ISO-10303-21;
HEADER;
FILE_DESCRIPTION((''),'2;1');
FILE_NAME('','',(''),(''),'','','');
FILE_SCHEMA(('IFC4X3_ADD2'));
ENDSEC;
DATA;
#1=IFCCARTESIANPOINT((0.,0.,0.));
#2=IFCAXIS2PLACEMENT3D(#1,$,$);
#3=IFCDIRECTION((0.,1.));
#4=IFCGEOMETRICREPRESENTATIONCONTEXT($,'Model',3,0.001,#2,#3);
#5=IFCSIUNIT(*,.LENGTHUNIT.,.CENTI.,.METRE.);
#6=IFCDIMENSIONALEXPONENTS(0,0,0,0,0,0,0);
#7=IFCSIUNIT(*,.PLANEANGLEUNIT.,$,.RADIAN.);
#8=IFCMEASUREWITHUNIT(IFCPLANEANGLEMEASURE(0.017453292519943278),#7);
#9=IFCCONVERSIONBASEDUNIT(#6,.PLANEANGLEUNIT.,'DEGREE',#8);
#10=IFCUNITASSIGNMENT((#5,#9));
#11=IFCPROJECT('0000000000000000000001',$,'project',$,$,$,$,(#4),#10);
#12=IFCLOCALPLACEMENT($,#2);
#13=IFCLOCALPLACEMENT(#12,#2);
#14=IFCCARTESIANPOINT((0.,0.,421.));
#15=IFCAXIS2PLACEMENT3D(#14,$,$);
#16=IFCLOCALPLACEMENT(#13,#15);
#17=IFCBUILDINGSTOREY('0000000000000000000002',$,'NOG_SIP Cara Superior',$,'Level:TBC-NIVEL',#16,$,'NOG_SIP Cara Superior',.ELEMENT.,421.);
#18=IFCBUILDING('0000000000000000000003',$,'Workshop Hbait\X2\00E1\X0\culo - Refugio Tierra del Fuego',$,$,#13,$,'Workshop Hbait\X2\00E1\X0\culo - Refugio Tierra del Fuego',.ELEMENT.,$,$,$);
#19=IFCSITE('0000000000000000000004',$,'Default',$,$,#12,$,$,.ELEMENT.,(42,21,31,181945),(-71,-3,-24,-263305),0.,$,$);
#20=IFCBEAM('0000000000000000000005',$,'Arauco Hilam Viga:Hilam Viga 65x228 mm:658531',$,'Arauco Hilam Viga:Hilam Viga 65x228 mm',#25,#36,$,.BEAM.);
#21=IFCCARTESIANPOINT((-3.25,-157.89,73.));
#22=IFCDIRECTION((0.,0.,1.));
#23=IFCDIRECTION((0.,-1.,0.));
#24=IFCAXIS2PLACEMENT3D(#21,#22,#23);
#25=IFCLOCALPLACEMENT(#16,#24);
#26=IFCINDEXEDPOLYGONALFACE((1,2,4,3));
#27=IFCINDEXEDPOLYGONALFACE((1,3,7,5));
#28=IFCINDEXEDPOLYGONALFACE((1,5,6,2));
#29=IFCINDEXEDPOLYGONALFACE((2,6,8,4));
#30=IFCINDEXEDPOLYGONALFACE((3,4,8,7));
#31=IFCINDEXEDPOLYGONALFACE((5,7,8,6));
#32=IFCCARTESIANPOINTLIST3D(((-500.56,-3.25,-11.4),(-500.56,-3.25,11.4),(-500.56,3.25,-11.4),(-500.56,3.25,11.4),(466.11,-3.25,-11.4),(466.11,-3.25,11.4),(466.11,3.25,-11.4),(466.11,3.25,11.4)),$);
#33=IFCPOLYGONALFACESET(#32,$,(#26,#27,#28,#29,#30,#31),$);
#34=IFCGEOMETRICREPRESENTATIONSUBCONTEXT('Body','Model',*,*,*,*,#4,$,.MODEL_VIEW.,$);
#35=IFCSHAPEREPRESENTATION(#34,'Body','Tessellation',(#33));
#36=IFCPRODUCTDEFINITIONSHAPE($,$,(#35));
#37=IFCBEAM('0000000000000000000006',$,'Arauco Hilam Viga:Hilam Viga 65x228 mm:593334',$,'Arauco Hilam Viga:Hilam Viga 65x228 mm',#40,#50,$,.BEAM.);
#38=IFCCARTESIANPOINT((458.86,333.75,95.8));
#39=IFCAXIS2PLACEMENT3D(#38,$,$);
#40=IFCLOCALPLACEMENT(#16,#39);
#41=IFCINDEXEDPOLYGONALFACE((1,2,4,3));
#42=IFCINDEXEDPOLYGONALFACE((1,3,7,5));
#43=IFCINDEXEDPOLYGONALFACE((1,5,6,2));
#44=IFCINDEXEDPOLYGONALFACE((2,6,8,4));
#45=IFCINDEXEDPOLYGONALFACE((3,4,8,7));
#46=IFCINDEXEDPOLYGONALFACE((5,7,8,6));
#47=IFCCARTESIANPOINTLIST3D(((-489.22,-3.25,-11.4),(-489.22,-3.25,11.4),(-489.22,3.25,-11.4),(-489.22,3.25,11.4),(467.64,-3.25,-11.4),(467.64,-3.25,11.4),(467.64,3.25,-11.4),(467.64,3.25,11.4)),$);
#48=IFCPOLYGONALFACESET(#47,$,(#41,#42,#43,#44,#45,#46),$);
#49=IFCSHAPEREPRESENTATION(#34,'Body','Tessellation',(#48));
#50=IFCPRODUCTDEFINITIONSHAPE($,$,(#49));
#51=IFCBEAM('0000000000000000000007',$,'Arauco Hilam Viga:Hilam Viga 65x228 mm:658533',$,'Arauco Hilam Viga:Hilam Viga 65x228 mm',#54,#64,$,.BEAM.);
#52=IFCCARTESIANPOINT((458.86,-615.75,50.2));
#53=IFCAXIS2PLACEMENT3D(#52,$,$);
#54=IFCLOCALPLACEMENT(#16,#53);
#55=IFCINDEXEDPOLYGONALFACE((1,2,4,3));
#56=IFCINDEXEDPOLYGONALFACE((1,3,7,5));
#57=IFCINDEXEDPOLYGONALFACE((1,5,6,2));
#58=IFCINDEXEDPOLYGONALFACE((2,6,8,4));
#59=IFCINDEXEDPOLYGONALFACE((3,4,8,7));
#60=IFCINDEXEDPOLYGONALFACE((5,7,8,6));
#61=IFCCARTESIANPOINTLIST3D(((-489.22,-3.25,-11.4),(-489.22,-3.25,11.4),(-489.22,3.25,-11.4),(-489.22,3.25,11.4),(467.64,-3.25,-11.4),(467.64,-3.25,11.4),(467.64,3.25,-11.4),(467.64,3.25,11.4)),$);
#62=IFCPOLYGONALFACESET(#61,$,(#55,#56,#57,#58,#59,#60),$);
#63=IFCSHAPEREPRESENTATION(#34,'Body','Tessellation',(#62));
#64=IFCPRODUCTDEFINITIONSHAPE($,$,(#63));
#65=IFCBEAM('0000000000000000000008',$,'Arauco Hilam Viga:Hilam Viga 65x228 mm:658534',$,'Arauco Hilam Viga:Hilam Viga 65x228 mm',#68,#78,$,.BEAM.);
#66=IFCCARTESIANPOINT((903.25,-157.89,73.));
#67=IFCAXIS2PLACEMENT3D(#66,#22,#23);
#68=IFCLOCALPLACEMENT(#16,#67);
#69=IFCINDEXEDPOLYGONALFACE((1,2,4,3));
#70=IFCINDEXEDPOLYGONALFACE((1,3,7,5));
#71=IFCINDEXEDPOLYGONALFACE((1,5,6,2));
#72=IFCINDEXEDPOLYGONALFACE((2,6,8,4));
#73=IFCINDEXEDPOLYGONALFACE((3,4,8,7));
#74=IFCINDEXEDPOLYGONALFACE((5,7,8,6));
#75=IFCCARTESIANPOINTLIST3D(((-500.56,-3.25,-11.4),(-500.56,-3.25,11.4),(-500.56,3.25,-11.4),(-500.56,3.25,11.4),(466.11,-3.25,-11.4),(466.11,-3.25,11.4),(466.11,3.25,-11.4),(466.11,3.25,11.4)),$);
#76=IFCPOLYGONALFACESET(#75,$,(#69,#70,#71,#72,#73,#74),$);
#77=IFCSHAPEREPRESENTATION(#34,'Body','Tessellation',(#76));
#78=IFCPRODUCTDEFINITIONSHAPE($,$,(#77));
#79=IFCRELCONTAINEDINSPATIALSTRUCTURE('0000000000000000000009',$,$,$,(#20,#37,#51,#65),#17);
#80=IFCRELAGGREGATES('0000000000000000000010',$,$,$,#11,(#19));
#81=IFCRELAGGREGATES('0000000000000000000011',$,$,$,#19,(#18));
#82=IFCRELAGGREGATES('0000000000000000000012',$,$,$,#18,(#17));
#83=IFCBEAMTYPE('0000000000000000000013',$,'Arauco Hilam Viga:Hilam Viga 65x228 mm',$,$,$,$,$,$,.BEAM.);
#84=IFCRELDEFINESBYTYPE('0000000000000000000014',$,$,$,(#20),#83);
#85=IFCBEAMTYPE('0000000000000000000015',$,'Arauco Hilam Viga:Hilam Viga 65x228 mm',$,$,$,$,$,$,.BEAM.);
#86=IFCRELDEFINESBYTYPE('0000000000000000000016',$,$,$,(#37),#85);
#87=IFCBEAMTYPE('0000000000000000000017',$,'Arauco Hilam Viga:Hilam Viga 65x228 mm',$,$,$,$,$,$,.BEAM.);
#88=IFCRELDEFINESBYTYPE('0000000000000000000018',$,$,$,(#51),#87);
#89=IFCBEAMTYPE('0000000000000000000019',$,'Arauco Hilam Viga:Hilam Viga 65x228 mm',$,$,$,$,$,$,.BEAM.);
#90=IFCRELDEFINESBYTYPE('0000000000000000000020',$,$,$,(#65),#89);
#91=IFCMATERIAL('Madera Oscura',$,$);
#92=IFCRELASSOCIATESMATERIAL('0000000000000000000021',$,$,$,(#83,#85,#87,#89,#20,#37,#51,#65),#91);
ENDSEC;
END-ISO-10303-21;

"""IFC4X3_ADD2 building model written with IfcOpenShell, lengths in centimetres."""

from ifc_helpers import new_model, entity, si_unit, converted_unit, direction, frame, origin, origin_2d_with_axis, place, context, subcontext, project, spatial, rectangle, extrude, source, transform, mapped, material, material_profile, profile_set, profile_usage, type_object, type_shapes, element, save


model = new_model("IFC4X3_ADD2")

# Units and contexts
model_context = context("Model", 3, precision=0.001, world=origin(), true_north=direction((0.0, 1.0)))
body_context = subcontext(model_context, "Body", "Model", "MODEL_VIEW")
ifc_project = project(units=[si_unit("LENGTHUNIT", "METRE", prefix="CENTI"), converted_unit("PLANEANGLEUNIT", "DEGREE", entity("IfcPlaneAngleMeasure", 0.017453292519943278), si_unit("PLANEANGLEUNIT", "RADIAN"), dimensions=[0, 0, 0, 0, 0, 0, 0])], contexts=[model_context])

# Site, building, storey
site_placement = place(None, origin())
site = spatial("IfcSite", under=ifc_project, at=site_placement, Name="Default", CompositionType="ELEMENT", RefLatitude=(42, 21, 31, 181945), RefLongitude=(-71, -3, -24, -263305), RefElevation=0.0)
building_placement = place(site_placement, origin())
building = spatial("IfcBuilding", under=site, at=building_placement, Name="Workshop Hbaitáculo - Refugio Tierra del Fuego", LongName="Workshop Hbaitáculo - Refugio Tierra del Fuego", CompositionType="ELEMENT")
storey_placement = place(building_placement, frame((0.0, 0.0, 421.0)))
storey = spatial("IfcBuildingStorey", under=building, at=storey_placement, Name="NOG_SIP Cara Superior", ObjectType="Level:TBC-NIVEL", LongName="NOG_SIP Cara Superior", CompositionType="ELEMENT", Elevation=421.0)

# Beams
ifc_material_1 = material(Name="Madera Oscura")
ifc_material_profile = material_profile(ifc_material_1, rectangle(XDim=930.0, YDim=6.5, at=origin_2d_with_axis()), Name="Hilam Viga 65x228 mm")
ifc_profile_set = profile_set([ifc_material_profile], Name="Hilam Viga 65x228 mm")
ifc_profile_usage = profile_usage(ifc_profile_set, cardinal=8)
beam_type_1 = type_object("IfcBeamType", Name="Arauco Hilam Viga:Hilam Viga 65x228 mm", PredefinedType="BEAM", material=ifc_profile_set)
shared_shape_1 = source(origin(), body_context, "Body", "SweptSolid", [
    extrude(rectangle(XDim=966.67, YDim=6.5, at=origin_2d_with_axis()), frame((-17.23, 0.0, -11.4), z_axis=(0.0, 0.0, 1.0), x_axis=(-1.0, 0.0, 0.0)), (0.0, 0.0, 1.0), 22.8),
])
type_shapes(beam_type_1, [shared_shape_1])
beam_1_placement = place(storey_placement, frame((-3.25, -157.89, 73.0), z_axis=(0.0, 0.0, 1.0), x_axis=(0.0, -1.0, 0.0)))
element("IfcBeam", 1, at=beam_1_placement, inside=storey, type_object=beam_type_1, material=ifc_profile_usage, Name="Arauco Hilam Viga:Hilam Viga 65x228 mm:658531", ObjectType="Arauco Hilam Viga:Hilam Viga 65x228 mm", PredefinedType="BEAM", context=body_context, shape_type="MappedRepresentation", body=[
    mapped(shared_shape_1, transform((0.0, 0.0, 0.0), scale=1.0)),
])
beam_type_2 = type_object("IfcBeamType", Name="Arauco Hilam Viga:Hilam Viga 65x228 mm", PredefinedType="BEAM", material=ifc_profile_set)
shared_shape_2 = source(origin(), body_context, "Body", "SweptSolid", [
    extrude(rectangle(XDim=956.86, YDim=6.5, at=origin_2d_with_axis()), frame((-10.79, 0.0, -11.4), z_axis=(0.0, 0.0, 1.0), x_axis=(-1.0, 0.0, 0.0)), (0.0, 0.0, 1.0), 22.8),
])
type_shapes(beam_type_2, [shared_shape_2])
beam_2_placement = place(storey_placement, frame((458.86, 333.75, 95.8)))
element("IfcBeam", 2, at=beam_2_placement, inside=storey, type_object=beam_type_2, material=ifc_profile_usage, Name="Arauco Hilam Viga:Hilam Viga 65x228 mm:593334", ObjectType="Arauco Hilam Viga:Hilam Viga 65x228 mm", PredefinedType="BEAM", context=body_context, shape_type="MappedRepresentation", body=[
    mapped(shared_shape_2, transform((0.0, 0.0, 0.0), scale=1.0)),
])
beam_type_3 = type_object("IfcBeamType", Name="Arauco Hilam Viga:Hilam Viga 65x228 mm", PredefinedType="BEAM", material=ifc_profile_set)
shared_shape_3 = source(origin(), body_context, "Body", "SweptSolid", [
    extrude(rectangle(XDim=6.5, YDim=956.86, at=origin_2d_with_axis()), frame((-10.79, 0.0, -11.4), z_axis=(0.0, 0.0, 1.0), x_axis=(0.0, 1.0, 0.0)), (0.0, 0.0, 1.0), 22.8),
])
type_shapes(beam_type_3, [shared_shape_3])
beam_3_placement = place(storey_placement, frame((458.86, -615.75, 50.2)))
element("IfcBeam", 3, at=beam_3_placement, inside=storey, type_object=beam_type_3, material=ifc_profile_usage, Name="Arauco Hilam Viga:Hilam Viga 65x228 mm:658533", ObjectType="Arauco Hilam Viga:Hilam Viga 65x228 mm", PredefinedType="BEAM", context=body_context, shape_type="MappedRepresentation", body=[
    mapped(shared_shape_3, transform((0.0, 0.0, 0.0), scale=1.0)),
])
beam_type_4 = type_object("IfcBeamType", Name="Arauco Hilam Viga:Hilam Viga 65x228 mm", PredefinedType="BEAM", material=ifc_profile_set)
shared_shape_4 = source(origin(), body_context, "Body", "SweptSolid", [
    extrude(rectangle(XDim=6.5, YDim=966.67, at=origin_2d_with_axis()), frame((-17.23, 0.0, -11.4), z_axis=(0.0, 0.0, 1.0), x_axis=(0.0, 1.0, 0.0)), (0.0, 0.0, 1.0), 22.8),
])
type_shapes(beam_type_4, [shared_shape_4])
beam_4_placement = place(storey_placement, frame((903.25, -157.89, 73.0), z_axis=(0.0, 0.0, 1.0), x_axis=(0.0, -1.0, 0.0)))
element("IfcBeam", 4, at=beam_4_placement, inside=storey, type_object=beam_type_4, material=ifc_profile_usage, Name="Arauco Hilam Viga:Hilam Viga 65x228 mm:658534", ObjectType="Arauco Hilam Viga:Hilam Viga 65x228 mm", PredefinedType="BEAM", context=body_context, shape_type="MappedRepresentation", body=[
    mapped(shared_shape_4, transform((0.0, 0.0, 0.0), scale=1.0)),
])

save(model, "model.ifc")
